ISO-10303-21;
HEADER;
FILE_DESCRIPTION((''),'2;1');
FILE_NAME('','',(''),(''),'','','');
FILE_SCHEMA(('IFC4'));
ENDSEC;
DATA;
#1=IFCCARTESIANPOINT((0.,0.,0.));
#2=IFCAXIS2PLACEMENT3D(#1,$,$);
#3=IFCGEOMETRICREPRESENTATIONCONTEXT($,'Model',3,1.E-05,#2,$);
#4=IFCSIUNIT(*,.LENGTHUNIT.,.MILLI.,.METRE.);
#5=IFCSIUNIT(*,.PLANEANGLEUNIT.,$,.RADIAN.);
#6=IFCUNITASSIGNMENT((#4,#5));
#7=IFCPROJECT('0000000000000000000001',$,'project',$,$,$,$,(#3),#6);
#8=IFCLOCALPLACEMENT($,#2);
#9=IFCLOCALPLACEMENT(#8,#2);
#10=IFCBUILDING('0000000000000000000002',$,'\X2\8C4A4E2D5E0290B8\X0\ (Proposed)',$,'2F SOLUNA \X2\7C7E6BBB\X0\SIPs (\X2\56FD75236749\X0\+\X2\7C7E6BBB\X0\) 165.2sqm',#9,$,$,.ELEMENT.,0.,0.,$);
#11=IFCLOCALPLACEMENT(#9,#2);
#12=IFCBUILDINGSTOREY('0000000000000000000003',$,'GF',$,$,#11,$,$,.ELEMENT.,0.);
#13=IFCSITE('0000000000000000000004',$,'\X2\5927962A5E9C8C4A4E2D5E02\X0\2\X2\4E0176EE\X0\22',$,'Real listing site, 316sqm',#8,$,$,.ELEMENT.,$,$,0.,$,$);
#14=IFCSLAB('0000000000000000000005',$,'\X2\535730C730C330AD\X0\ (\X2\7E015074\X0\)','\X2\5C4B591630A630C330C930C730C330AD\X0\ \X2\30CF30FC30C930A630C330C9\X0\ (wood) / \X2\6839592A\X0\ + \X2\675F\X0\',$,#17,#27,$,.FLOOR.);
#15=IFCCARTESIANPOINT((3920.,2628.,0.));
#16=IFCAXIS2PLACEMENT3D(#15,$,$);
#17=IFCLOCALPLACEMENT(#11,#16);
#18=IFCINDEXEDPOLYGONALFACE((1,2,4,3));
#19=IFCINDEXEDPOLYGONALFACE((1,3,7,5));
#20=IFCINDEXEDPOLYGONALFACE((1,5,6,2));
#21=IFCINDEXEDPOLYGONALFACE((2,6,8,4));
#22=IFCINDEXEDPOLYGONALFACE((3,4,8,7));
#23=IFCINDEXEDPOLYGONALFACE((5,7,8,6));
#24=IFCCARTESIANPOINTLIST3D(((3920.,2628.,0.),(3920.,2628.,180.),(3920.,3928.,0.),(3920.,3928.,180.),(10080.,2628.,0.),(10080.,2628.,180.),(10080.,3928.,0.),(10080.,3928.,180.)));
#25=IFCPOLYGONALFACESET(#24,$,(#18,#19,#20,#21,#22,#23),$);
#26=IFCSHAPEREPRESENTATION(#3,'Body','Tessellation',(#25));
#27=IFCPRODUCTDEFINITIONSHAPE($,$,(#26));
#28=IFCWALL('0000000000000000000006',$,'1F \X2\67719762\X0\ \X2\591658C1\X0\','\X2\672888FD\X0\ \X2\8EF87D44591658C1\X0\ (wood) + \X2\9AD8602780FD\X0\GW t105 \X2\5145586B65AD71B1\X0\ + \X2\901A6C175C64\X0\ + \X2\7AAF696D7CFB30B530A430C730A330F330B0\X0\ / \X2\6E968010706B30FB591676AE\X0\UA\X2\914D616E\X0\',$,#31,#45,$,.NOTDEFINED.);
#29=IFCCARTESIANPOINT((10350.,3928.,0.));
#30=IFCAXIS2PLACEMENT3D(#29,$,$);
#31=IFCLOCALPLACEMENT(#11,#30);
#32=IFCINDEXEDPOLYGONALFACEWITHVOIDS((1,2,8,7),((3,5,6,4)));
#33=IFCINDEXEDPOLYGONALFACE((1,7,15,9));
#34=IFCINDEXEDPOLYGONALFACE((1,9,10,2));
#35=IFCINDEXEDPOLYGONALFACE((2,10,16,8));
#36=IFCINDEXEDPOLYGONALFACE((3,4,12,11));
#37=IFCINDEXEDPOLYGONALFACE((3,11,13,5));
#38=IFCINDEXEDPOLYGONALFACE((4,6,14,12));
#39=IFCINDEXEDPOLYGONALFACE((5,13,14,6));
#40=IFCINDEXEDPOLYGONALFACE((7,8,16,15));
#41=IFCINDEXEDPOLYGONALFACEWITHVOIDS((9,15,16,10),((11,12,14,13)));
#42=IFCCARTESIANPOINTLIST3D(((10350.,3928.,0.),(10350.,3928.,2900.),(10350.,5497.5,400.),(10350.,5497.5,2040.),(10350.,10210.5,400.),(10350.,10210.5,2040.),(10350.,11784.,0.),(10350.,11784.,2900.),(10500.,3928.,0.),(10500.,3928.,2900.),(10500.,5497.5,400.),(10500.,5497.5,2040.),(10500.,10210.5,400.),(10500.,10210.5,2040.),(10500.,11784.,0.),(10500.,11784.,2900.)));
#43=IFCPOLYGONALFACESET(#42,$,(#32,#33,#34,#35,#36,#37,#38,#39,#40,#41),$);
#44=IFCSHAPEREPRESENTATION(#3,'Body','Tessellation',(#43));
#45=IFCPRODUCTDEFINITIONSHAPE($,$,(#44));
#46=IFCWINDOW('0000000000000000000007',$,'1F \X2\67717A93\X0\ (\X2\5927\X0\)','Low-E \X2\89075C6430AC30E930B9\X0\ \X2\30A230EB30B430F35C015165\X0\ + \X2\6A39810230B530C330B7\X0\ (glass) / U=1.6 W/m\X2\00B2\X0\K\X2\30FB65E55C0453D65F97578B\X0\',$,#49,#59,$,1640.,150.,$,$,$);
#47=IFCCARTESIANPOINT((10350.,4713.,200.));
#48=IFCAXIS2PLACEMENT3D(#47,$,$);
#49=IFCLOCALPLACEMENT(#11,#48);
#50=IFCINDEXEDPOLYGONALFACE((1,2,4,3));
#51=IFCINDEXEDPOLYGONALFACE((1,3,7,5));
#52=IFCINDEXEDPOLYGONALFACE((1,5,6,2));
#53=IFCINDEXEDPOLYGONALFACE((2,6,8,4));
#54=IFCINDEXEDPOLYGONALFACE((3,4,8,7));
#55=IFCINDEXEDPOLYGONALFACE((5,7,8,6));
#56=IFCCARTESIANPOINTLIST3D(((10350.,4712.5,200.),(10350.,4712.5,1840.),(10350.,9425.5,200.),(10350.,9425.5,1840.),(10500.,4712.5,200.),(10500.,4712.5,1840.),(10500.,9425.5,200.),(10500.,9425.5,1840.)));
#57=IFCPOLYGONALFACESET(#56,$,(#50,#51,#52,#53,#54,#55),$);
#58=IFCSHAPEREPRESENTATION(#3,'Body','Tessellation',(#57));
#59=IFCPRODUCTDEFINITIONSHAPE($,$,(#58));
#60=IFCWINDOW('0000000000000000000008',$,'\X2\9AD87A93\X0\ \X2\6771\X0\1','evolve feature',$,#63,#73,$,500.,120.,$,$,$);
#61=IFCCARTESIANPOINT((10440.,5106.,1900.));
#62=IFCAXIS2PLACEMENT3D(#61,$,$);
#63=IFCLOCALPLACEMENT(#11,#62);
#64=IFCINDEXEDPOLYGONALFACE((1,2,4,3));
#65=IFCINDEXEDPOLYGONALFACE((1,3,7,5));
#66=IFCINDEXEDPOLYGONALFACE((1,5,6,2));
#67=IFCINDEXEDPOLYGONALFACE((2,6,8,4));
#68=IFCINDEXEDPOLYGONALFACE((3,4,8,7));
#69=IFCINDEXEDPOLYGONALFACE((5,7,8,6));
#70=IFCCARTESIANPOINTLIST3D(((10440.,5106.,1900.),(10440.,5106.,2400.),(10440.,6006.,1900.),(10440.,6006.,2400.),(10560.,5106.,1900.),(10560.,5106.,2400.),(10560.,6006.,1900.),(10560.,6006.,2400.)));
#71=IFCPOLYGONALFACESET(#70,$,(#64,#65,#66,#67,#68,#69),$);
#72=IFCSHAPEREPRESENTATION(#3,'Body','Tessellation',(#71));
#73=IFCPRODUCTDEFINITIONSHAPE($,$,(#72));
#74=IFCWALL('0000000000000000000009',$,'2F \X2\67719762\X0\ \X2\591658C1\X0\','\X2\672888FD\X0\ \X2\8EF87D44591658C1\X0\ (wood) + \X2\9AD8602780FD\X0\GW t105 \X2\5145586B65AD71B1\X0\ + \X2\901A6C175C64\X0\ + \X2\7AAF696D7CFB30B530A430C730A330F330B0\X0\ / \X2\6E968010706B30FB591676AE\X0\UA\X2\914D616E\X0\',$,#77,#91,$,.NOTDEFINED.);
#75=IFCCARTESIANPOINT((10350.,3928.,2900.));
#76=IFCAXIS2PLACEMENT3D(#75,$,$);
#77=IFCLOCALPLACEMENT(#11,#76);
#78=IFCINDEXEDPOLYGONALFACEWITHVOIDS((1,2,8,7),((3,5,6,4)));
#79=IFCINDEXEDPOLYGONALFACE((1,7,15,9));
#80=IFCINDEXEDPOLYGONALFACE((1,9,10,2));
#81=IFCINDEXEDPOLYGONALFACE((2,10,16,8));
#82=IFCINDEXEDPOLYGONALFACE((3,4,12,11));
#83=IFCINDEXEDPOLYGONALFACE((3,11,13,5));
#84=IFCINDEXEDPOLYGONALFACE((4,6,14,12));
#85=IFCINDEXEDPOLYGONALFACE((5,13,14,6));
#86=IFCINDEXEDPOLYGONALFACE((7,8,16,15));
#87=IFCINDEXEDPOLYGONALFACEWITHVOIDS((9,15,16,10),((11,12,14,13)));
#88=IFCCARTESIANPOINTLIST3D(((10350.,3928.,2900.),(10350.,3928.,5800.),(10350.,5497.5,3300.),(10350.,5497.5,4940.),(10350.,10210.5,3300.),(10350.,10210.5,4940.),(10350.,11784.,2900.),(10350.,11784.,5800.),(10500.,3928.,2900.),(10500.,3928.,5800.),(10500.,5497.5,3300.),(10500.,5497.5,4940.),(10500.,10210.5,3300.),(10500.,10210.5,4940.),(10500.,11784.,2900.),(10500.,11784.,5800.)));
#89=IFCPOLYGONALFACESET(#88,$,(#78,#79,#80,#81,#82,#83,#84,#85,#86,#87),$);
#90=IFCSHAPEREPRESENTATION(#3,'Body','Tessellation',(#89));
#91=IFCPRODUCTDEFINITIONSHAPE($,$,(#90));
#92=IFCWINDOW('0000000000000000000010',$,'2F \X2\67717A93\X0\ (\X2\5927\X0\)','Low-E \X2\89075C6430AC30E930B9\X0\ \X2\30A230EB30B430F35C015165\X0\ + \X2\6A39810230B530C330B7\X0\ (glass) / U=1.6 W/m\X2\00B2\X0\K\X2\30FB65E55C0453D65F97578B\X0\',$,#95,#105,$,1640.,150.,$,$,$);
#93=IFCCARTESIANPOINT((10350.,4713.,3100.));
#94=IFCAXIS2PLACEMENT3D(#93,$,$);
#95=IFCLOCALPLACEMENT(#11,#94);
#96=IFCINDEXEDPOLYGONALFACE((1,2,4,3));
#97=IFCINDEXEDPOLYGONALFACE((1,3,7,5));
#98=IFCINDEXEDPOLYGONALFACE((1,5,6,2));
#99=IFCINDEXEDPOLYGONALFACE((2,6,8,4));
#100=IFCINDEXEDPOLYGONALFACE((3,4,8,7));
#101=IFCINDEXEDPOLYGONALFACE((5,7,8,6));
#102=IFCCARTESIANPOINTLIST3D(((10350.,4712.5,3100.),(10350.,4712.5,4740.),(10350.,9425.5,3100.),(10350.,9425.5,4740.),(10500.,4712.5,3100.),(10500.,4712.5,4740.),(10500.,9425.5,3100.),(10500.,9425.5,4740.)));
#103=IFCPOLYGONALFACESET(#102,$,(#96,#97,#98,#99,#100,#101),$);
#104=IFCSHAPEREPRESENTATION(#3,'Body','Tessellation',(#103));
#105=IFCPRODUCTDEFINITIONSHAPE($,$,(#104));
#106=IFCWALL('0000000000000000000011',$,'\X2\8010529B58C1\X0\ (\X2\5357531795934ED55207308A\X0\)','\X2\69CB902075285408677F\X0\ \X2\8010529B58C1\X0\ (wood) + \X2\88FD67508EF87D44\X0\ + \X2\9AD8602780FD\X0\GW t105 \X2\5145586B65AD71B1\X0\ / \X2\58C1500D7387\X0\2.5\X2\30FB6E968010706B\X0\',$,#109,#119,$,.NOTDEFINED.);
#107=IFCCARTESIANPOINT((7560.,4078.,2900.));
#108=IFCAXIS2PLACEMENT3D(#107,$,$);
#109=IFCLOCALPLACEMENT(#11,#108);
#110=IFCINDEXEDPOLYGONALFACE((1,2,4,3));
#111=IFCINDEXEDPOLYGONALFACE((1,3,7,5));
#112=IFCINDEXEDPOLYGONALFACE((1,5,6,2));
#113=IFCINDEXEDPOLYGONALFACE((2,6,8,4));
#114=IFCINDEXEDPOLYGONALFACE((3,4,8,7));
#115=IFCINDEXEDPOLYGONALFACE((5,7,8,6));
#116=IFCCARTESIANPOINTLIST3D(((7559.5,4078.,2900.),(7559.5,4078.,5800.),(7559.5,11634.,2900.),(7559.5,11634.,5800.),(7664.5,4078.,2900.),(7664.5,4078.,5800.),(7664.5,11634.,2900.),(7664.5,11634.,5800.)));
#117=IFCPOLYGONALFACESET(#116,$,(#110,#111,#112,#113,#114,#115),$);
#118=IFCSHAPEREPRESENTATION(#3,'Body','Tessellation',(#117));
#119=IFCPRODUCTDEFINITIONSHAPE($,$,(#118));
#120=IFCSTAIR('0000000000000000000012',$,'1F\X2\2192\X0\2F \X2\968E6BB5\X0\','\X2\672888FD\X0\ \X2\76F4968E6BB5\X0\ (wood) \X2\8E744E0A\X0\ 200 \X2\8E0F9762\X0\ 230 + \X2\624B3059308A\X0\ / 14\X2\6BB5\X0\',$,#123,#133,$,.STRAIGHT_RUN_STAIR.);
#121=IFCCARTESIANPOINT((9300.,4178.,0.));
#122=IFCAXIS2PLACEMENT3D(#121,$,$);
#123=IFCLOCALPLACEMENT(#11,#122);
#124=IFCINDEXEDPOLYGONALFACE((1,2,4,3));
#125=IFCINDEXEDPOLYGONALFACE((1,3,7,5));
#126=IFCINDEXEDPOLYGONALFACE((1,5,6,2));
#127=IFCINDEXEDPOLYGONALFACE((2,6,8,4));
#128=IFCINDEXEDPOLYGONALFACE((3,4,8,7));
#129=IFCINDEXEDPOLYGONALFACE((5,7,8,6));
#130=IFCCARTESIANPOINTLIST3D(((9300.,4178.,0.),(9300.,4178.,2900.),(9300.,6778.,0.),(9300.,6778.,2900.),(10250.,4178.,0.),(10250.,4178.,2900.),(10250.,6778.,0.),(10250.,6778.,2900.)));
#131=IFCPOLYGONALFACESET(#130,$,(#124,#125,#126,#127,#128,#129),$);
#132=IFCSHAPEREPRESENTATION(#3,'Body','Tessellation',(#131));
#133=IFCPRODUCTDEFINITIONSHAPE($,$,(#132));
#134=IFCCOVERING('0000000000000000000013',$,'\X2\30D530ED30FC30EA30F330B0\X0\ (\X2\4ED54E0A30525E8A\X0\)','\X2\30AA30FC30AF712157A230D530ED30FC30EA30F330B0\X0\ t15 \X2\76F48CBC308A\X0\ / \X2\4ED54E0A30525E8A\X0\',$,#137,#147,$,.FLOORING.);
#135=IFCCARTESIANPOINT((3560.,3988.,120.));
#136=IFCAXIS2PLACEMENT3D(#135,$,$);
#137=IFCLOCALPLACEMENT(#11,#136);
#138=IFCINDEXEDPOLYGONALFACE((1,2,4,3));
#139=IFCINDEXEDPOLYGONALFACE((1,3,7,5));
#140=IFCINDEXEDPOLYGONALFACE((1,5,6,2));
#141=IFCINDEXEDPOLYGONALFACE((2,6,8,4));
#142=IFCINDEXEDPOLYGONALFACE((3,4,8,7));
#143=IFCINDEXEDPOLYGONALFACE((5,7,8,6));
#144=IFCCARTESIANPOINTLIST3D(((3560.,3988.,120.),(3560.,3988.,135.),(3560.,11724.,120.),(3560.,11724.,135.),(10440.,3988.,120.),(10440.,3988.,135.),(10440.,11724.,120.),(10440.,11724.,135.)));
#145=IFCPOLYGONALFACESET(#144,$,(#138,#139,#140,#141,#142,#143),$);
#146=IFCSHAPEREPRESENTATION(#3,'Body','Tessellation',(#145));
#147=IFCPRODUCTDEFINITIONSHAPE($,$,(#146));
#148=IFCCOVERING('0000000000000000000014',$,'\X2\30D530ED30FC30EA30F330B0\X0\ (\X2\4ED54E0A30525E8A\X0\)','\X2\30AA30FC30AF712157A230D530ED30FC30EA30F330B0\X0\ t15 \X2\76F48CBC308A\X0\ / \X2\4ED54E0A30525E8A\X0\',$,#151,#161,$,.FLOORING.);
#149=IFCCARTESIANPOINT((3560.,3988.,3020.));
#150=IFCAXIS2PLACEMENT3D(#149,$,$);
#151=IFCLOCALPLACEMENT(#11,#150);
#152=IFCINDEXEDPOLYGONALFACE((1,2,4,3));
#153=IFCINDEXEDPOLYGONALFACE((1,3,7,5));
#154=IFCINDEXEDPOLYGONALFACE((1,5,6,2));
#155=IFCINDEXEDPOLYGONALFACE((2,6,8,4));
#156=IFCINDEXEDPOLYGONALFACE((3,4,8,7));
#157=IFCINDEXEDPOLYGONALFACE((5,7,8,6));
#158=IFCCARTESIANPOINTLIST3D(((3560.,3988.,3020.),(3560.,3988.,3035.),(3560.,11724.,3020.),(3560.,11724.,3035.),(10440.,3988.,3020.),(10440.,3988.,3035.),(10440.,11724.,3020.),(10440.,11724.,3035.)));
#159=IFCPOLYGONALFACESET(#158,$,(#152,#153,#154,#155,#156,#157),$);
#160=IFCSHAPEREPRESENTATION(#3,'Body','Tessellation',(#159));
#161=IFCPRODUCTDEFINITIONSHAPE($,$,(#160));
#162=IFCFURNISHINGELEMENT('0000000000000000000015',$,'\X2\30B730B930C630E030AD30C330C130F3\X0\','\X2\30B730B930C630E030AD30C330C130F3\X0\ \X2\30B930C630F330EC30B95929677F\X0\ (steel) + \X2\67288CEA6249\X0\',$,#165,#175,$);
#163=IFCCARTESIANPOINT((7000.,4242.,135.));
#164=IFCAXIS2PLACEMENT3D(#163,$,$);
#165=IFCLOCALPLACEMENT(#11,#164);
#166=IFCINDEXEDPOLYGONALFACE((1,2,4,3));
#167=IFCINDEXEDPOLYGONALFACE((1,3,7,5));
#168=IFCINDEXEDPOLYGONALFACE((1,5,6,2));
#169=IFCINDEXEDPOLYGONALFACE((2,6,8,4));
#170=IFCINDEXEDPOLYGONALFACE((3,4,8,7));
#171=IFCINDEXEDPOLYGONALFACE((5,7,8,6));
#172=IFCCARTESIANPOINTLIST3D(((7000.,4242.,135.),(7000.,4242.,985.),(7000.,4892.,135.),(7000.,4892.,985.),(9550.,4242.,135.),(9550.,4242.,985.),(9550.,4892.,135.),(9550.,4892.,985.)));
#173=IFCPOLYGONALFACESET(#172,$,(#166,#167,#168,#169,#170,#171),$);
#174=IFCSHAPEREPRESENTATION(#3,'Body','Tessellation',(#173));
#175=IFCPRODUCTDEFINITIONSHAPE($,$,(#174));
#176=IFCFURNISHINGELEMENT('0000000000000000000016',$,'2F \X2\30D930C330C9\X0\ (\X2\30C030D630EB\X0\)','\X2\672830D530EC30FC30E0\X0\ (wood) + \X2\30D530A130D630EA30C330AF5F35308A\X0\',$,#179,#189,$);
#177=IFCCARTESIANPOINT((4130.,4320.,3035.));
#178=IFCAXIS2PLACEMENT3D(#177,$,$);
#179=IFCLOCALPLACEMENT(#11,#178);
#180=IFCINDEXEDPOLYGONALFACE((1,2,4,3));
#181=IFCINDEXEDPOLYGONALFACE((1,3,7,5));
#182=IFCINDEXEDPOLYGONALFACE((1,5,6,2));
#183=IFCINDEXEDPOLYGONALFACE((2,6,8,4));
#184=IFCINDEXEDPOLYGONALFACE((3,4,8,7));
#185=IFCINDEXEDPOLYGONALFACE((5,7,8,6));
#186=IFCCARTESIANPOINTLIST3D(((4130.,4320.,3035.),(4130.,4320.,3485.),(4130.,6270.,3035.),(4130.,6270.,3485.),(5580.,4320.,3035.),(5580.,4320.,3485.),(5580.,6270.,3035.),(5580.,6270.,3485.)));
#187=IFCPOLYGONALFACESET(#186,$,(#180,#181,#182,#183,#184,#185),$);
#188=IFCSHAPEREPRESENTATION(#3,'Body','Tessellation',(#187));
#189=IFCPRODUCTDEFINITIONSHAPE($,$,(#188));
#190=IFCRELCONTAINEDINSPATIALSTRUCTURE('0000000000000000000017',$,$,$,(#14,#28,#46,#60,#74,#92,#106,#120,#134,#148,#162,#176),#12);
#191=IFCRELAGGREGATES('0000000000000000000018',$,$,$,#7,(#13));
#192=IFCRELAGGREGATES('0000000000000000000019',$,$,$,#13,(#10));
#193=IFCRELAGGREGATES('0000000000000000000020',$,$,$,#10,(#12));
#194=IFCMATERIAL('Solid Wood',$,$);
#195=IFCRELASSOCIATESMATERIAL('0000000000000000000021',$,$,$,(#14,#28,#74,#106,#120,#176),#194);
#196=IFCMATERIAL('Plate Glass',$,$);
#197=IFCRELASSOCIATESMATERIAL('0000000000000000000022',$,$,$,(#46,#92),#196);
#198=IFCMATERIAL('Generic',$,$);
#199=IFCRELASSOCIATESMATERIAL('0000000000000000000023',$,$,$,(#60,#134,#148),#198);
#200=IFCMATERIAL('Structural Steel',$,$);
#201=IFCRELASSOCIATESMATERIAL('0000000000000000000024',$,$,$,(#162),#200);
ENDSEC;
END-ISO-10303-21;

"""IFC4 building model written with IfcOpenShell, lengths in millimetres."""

from ifc_helpers import new_model, si_unit, frame, frame_2d, origin, place, context, project, spatial, rectangle, extrude, material, element, fill, save


model = new_model("IFC4")

# Units and contexts
model_context = context("Model", 3, precision=1e-05, world=origin())
ifc_project = project(units=[si_unit("LENGTHUNIT", "METRE", prefix="MILLI"), si_unit("PLANEANGLEUNIT", "RADIAN")], contexts=[model_context])

# Site, building, storey
site_placement = place(None, origin())
site = spatial("IfcSite", under=ifc_project, at=site_placement, Name="大阪府豊中市2丁目22", ObjectType="Real listing site, 316sqm", CompositionType="ELEMENT", RefElevation=0.0)
building_placement = place(site_placement, origin())
building = spatial("IfcBuilding", under=site, at=building_placement, Name="豊中市邸 (Proposed)", ObjectType="2F SOLUNA 籾殻SIPs (国産杉+籾殻) 165.2sqm", CompositionType="ELEMENT", ElevationOfRefHeight=0.0, ElevationOfTerrain=0.0)
storey_placement = place(building_placement, origin())
storey = spatial("IfcBuildingStorey", under=building, at=storey_placement, Name="GF", CompositionType="ELEMENT", Elevation=0.0)

# Slab
ifc_material_1 = material(Name="Solid Wood")
slab_placement = place(storey_placement, frame((3920.0, 2628.0, 0.0)))
element("IfcSlab", 1, at=slab_placement, inside=storey, material=ifc_material_1, Name="南デッキ (縁側)", Description="屋外ウッドデッキ ハードウッド (wood) / 根太 + 束", PredefinedType="FLOOR", context=model_context, shape_type="SweptSolid", body=[
    extrude(rectangle(XDim=6160.0, YDim=1300.0, at=frame_2d((3080.0, 650.0))), frame((3920.0, 2628.0, 0.0)), (0.0, 0.0, 1.0), 180.0),
])

# Wall, openings, windows
wall_1_placement = place(storey_placement, frame((10350.0, 3928.0, 0.0)))
wall_1 = element("IfcWall", 2, at=wall_1_placement, inside=storey, material=ifc_material_1, Name="1F 東面 外壁", Description="木製 軸組外壁 (wood) + 高性能GW t105 充填断熱 + 通気層 + 窯業系サイディング / 準耐火・外皮UA配慮", PredefinedType="NOTDEFINED", context=model_context, shape_type="SweptSolid", body=[
    extrude(rectangle(XDim=150.0, YDim=7856.0, at=frame_2d((75.0, 3928.0))), frame((10350.0, 3928.0, 0.0)), (0.0, 0.0, 1.0), 2900.0),
])
opening_1_placement = place(storey_placement, frame((10350.0, 4713.0, 200.0)))
opening_1 = element("IfcOpeningElement", 3, at=opening_1_placement, cuts=wall_1, PredefinedType="NOTDEFINED", context=model_context, shape_type="SweptSolid", body=[
    extrude(rectangle(XDim=150.0, YDim=4713.0, at=frame_2d((75.0, 2356.0))), frame((10350.0, 4713.0, 200.0)), (0.0, 0.0, 1.0), 1640.0),
])
opening_2_placement = place(storey_placement, frame((10440.0, 5106.0, 1900.0)))
opening_2 = element("IfcOpeningElement", 4, at=opening_2_placement, cuts=wall_1, PredefinedType="NOTDEFINED", context=model_context, shape_type="SweptSolid", body=[
    extrude(rectangle(XDim=120.0, YDim=900.0, at=frame_2d((60.0, 450.0))), frame((10440.0, 5106.0, 1900.0)), (0.0, 0.0, 1.0), 500.0),
])
ifc_material_2 = material(Name="Plate Glass")
window_1_placement = place(storey_placement, frame((10350.0, 4713.0, 200.0)))
window_1 = element("IfcWindow", 5, at=window_1_placement, inside=storey, material=ifc_material_2, Name="1F 東窓 (大)", Description="Low-E 複層ガラス アルゴン封入 + 樹脂サッシ (glass) / U=1.6 W/m²K・日射取得型", OverallHeight=1640.0, OverallWidth=150.0, context=model_context, shape_type="SweptSolid", body=[
    extrude(rectangle(XDim=150.0, YDim=4713.0, at=frame_2d((75.0, 2356.0))), frame((10350.0, 4713.0, 200.0)), (0.0, 0.0, 1.0), 1640.0),
])
fill(opening_1, window_1)
ifc_material_3 = material(Name="Generic")
window_2_placement = place(storey_placement, frame((10440.0, 5106.0, 1900.0)))
window_2 = element("IfcWindow", 6, at=window_2_placement, inside=storey, material=ifc_material_3, Name="高窓 東1", Description="evolve feature", OverallHeight=500.0, OverallWidth=120.0, context=model_context, shape_type="SweptSolid", body=[
    extrude(rectangle(XDim=120.0, YDim=900.0, at=frame_2d((60.0, 450.0))), frame((10440.0, 5106.0, 1900.0)), (0.0, 0.0, 1.0), 500.0),
])
fill(opening_2, window_2)

# Wall, opening, window
wall_2_placement = place(storey_placement, frame((10350.0, 3928.0, 2900.0)))
wall_2 = element("IfcWall", 7, at=wall_2_placement, inside=storey, material=ifc_material_1, Name="2F 東面 外壁", Description="木製 軸組外壁 (wood) + 高性能GW t105 充填断熱 + 通気層 + 窯業系サイディング / 準耐火・外皮UA配慮", PredefinedType="NOTDEFINED", context=model_context, shape_type="SweptSolid", body=[
    extrude(rectangle(XDim=150.0, YDim=7856.0, at=frame_2d((75.0, 3928.0))), frame((10350.0, 3928.0, 2900.0)), (0.0, 0.0, 1.0), 2900.0),
])
opening_3_placement = place(storey_placement, frame((10350.0, 4713.0, 3100.0)))
opening_3 = element("IfcOpeningElement", 8, at=opening_3_placement, cuts=wall_2, PredefinedType="NOTDEFINED", context=model_context, shape_type="SweptSolid", body=[
    extrude(rectangle(XDim=150.0, YDim=4713.0, at=frame_2d((75.0, 2356.0))), frame((10350.0, 4713.0, 3100.0)), (0.0, 0.0, 1.0), 1640.0),
])
window_3_placement = place(storey_placement, frame((10350.0, 4713.0, 3100.0)))
window_3 = element("IfcWindow", 9, at=window_3_placement, inside=storey, material=ifc_material_2, Name="2F 東窓 (大)", Description="Low-E 複層ガラス アルゴン封入 + 樹脂サッシ (glass) / U=1.6 W/m²K・日射取得型", OverallHeight=1640.0, OverallWidth=150.0, context=model_context, shape_type="SweptSolid", body=[
    extrude(rectangle(XDim=150.0, YDim=4713.0, at=frame_2d((75.0, 2356.0))), frame((10350.0, 4713.0, 3100.0)), (0.0, 0.0, 1.0), 1640.0),
])
fill(opening_3, window_3)

# Wall
wall_3_placement = place(storey_placement, frame((7560.0, 4078.0, 2900.0)))
element("IfcWall", 10, at=wall_3_placement, inside=storey, material=ifc_material_1, Name="耐力壁 (南北間仕切り)", Description="構造用合板 耐力壁 (wood) + 製材軸組 + 高性能GW t105 充填断熱 / 壁倍率2.5・準耐火", PredefinedType="NOTDEFINED", context=model_context, shape_type="SweptSolid", body=[
    extrude(rectangle(XDim=105.0, YDim=7556.0, at=frame_2d((52.0, 3778.0))), frame((7560.0, 4078.0, 2900.0)), (0.0, 0.0, 1.0), 2900.0),
])

# Stair
stair_placement = place(storey_placement, frame((9300.0, 4178.0, 0.0)))
element("IfcStair", 11, at=stair_placement, inside=storey, material=ifc_material_1, Name="1F→2F 階段", Description="木製 直階段 (wood) 蹴上 200 踏面 230 + 手すり / 14段", PredefinedType="STRAIGHT_RUN_STAIR", context=model_context, shape_type="SweptSolid", body=[
    extrude(rectangle(XDim=950.0, YDim=2600.0, at=frame_2d((475.0, 1300.0))), frame((9300.0, 4178.0, 0.0)), (0.0, 0.0, 1.0), 2900.0),
])

# Coverings
covering_1_placement = place(storey_placement, frame((3560.0, 3988.0, 120.0)))
element("IfcCovering", 12, at=covering_1_placement, inside=storey, material=ifc_material_3, Name="フローリング (仕上げ床)", Description="オーク無垢フローリング t15 直貼り / 仕上げ床", PredefinedType="FLOORING", context=model_context, shape_type="SweptSolid", body=[
    extrude(rectangle(XDim=6880.0, YDim=7736.0, at=frame_2d((3440.0, 3868.0))), frame((3560.0, 3988.0, 120.0)), (0.0, 0.0, 1.0), 15.0),
])
covering_2_placement = place(storey_placement, frame((3560.0, 3988.0, 3020.0)))
element("IfcCovering", 13, at=covering_2_placement, inside=storey, material=ifc_material_3, Name="フローリング (仕上げ床)", Description="オーク無垢フローリング t15 直貼り / 仕上げ床", PredefinedType="FLOORING", context=model_context, shape_type="SweptSolid", body=[
    extrude(rectangle(XDim=6880.0, YDim=7736.0, at=frame_2d((3440.0, 3868.0))), frame((3560.0, 3988.0, 3020.0)), (0.0, 0.0, 1.0), 15.0),
])

# Furnishing elements
ifc_material_4 = material(Name="Structural Steel")
furnishing_1_placement = place(storey_placement, frame((7000.0, 4242.0, 135.0)))
element("IfcFurnishingElement", 14, at=furnishing_1_placement, inside=storey, material=ifc_material_4, Name="システムキッチン", Description="システムキッチン ステンレス天板 (steel) + 木質扉", context=model_context, shape_type="SweptSolid", body=[
    extrude(rectangle(XDim=2550.0, YDim=650.0, at=frame_2d((1275.0, 325.0))), frame((7000.0, 4242.0, 135.0)), (0.0, 0.0, 1.0), 850.0),
])
furnishing_2_placement = place(storey_placement, frame((4130.0, 4320.0, 3035.0)))
element("IfcFurnishingElement", 15, at=furnishing_2_placement, inside=storey, material=ifc_material_1, Name="2F ベッド (ダブル)", Description="木フレーム (wood) + ファブリック張り", context=model_context, shape_type="SweptSolid", body=[
    extrude(rectangle(XDim=1450.0, YDim=1950.0, at=frame_2d((725.0, 975.0))), frame((4130.0, 4320.0, 3035.0)), (0.0, 0.0, 1.0), 450.0),
])

save(model, "model.ifc")
